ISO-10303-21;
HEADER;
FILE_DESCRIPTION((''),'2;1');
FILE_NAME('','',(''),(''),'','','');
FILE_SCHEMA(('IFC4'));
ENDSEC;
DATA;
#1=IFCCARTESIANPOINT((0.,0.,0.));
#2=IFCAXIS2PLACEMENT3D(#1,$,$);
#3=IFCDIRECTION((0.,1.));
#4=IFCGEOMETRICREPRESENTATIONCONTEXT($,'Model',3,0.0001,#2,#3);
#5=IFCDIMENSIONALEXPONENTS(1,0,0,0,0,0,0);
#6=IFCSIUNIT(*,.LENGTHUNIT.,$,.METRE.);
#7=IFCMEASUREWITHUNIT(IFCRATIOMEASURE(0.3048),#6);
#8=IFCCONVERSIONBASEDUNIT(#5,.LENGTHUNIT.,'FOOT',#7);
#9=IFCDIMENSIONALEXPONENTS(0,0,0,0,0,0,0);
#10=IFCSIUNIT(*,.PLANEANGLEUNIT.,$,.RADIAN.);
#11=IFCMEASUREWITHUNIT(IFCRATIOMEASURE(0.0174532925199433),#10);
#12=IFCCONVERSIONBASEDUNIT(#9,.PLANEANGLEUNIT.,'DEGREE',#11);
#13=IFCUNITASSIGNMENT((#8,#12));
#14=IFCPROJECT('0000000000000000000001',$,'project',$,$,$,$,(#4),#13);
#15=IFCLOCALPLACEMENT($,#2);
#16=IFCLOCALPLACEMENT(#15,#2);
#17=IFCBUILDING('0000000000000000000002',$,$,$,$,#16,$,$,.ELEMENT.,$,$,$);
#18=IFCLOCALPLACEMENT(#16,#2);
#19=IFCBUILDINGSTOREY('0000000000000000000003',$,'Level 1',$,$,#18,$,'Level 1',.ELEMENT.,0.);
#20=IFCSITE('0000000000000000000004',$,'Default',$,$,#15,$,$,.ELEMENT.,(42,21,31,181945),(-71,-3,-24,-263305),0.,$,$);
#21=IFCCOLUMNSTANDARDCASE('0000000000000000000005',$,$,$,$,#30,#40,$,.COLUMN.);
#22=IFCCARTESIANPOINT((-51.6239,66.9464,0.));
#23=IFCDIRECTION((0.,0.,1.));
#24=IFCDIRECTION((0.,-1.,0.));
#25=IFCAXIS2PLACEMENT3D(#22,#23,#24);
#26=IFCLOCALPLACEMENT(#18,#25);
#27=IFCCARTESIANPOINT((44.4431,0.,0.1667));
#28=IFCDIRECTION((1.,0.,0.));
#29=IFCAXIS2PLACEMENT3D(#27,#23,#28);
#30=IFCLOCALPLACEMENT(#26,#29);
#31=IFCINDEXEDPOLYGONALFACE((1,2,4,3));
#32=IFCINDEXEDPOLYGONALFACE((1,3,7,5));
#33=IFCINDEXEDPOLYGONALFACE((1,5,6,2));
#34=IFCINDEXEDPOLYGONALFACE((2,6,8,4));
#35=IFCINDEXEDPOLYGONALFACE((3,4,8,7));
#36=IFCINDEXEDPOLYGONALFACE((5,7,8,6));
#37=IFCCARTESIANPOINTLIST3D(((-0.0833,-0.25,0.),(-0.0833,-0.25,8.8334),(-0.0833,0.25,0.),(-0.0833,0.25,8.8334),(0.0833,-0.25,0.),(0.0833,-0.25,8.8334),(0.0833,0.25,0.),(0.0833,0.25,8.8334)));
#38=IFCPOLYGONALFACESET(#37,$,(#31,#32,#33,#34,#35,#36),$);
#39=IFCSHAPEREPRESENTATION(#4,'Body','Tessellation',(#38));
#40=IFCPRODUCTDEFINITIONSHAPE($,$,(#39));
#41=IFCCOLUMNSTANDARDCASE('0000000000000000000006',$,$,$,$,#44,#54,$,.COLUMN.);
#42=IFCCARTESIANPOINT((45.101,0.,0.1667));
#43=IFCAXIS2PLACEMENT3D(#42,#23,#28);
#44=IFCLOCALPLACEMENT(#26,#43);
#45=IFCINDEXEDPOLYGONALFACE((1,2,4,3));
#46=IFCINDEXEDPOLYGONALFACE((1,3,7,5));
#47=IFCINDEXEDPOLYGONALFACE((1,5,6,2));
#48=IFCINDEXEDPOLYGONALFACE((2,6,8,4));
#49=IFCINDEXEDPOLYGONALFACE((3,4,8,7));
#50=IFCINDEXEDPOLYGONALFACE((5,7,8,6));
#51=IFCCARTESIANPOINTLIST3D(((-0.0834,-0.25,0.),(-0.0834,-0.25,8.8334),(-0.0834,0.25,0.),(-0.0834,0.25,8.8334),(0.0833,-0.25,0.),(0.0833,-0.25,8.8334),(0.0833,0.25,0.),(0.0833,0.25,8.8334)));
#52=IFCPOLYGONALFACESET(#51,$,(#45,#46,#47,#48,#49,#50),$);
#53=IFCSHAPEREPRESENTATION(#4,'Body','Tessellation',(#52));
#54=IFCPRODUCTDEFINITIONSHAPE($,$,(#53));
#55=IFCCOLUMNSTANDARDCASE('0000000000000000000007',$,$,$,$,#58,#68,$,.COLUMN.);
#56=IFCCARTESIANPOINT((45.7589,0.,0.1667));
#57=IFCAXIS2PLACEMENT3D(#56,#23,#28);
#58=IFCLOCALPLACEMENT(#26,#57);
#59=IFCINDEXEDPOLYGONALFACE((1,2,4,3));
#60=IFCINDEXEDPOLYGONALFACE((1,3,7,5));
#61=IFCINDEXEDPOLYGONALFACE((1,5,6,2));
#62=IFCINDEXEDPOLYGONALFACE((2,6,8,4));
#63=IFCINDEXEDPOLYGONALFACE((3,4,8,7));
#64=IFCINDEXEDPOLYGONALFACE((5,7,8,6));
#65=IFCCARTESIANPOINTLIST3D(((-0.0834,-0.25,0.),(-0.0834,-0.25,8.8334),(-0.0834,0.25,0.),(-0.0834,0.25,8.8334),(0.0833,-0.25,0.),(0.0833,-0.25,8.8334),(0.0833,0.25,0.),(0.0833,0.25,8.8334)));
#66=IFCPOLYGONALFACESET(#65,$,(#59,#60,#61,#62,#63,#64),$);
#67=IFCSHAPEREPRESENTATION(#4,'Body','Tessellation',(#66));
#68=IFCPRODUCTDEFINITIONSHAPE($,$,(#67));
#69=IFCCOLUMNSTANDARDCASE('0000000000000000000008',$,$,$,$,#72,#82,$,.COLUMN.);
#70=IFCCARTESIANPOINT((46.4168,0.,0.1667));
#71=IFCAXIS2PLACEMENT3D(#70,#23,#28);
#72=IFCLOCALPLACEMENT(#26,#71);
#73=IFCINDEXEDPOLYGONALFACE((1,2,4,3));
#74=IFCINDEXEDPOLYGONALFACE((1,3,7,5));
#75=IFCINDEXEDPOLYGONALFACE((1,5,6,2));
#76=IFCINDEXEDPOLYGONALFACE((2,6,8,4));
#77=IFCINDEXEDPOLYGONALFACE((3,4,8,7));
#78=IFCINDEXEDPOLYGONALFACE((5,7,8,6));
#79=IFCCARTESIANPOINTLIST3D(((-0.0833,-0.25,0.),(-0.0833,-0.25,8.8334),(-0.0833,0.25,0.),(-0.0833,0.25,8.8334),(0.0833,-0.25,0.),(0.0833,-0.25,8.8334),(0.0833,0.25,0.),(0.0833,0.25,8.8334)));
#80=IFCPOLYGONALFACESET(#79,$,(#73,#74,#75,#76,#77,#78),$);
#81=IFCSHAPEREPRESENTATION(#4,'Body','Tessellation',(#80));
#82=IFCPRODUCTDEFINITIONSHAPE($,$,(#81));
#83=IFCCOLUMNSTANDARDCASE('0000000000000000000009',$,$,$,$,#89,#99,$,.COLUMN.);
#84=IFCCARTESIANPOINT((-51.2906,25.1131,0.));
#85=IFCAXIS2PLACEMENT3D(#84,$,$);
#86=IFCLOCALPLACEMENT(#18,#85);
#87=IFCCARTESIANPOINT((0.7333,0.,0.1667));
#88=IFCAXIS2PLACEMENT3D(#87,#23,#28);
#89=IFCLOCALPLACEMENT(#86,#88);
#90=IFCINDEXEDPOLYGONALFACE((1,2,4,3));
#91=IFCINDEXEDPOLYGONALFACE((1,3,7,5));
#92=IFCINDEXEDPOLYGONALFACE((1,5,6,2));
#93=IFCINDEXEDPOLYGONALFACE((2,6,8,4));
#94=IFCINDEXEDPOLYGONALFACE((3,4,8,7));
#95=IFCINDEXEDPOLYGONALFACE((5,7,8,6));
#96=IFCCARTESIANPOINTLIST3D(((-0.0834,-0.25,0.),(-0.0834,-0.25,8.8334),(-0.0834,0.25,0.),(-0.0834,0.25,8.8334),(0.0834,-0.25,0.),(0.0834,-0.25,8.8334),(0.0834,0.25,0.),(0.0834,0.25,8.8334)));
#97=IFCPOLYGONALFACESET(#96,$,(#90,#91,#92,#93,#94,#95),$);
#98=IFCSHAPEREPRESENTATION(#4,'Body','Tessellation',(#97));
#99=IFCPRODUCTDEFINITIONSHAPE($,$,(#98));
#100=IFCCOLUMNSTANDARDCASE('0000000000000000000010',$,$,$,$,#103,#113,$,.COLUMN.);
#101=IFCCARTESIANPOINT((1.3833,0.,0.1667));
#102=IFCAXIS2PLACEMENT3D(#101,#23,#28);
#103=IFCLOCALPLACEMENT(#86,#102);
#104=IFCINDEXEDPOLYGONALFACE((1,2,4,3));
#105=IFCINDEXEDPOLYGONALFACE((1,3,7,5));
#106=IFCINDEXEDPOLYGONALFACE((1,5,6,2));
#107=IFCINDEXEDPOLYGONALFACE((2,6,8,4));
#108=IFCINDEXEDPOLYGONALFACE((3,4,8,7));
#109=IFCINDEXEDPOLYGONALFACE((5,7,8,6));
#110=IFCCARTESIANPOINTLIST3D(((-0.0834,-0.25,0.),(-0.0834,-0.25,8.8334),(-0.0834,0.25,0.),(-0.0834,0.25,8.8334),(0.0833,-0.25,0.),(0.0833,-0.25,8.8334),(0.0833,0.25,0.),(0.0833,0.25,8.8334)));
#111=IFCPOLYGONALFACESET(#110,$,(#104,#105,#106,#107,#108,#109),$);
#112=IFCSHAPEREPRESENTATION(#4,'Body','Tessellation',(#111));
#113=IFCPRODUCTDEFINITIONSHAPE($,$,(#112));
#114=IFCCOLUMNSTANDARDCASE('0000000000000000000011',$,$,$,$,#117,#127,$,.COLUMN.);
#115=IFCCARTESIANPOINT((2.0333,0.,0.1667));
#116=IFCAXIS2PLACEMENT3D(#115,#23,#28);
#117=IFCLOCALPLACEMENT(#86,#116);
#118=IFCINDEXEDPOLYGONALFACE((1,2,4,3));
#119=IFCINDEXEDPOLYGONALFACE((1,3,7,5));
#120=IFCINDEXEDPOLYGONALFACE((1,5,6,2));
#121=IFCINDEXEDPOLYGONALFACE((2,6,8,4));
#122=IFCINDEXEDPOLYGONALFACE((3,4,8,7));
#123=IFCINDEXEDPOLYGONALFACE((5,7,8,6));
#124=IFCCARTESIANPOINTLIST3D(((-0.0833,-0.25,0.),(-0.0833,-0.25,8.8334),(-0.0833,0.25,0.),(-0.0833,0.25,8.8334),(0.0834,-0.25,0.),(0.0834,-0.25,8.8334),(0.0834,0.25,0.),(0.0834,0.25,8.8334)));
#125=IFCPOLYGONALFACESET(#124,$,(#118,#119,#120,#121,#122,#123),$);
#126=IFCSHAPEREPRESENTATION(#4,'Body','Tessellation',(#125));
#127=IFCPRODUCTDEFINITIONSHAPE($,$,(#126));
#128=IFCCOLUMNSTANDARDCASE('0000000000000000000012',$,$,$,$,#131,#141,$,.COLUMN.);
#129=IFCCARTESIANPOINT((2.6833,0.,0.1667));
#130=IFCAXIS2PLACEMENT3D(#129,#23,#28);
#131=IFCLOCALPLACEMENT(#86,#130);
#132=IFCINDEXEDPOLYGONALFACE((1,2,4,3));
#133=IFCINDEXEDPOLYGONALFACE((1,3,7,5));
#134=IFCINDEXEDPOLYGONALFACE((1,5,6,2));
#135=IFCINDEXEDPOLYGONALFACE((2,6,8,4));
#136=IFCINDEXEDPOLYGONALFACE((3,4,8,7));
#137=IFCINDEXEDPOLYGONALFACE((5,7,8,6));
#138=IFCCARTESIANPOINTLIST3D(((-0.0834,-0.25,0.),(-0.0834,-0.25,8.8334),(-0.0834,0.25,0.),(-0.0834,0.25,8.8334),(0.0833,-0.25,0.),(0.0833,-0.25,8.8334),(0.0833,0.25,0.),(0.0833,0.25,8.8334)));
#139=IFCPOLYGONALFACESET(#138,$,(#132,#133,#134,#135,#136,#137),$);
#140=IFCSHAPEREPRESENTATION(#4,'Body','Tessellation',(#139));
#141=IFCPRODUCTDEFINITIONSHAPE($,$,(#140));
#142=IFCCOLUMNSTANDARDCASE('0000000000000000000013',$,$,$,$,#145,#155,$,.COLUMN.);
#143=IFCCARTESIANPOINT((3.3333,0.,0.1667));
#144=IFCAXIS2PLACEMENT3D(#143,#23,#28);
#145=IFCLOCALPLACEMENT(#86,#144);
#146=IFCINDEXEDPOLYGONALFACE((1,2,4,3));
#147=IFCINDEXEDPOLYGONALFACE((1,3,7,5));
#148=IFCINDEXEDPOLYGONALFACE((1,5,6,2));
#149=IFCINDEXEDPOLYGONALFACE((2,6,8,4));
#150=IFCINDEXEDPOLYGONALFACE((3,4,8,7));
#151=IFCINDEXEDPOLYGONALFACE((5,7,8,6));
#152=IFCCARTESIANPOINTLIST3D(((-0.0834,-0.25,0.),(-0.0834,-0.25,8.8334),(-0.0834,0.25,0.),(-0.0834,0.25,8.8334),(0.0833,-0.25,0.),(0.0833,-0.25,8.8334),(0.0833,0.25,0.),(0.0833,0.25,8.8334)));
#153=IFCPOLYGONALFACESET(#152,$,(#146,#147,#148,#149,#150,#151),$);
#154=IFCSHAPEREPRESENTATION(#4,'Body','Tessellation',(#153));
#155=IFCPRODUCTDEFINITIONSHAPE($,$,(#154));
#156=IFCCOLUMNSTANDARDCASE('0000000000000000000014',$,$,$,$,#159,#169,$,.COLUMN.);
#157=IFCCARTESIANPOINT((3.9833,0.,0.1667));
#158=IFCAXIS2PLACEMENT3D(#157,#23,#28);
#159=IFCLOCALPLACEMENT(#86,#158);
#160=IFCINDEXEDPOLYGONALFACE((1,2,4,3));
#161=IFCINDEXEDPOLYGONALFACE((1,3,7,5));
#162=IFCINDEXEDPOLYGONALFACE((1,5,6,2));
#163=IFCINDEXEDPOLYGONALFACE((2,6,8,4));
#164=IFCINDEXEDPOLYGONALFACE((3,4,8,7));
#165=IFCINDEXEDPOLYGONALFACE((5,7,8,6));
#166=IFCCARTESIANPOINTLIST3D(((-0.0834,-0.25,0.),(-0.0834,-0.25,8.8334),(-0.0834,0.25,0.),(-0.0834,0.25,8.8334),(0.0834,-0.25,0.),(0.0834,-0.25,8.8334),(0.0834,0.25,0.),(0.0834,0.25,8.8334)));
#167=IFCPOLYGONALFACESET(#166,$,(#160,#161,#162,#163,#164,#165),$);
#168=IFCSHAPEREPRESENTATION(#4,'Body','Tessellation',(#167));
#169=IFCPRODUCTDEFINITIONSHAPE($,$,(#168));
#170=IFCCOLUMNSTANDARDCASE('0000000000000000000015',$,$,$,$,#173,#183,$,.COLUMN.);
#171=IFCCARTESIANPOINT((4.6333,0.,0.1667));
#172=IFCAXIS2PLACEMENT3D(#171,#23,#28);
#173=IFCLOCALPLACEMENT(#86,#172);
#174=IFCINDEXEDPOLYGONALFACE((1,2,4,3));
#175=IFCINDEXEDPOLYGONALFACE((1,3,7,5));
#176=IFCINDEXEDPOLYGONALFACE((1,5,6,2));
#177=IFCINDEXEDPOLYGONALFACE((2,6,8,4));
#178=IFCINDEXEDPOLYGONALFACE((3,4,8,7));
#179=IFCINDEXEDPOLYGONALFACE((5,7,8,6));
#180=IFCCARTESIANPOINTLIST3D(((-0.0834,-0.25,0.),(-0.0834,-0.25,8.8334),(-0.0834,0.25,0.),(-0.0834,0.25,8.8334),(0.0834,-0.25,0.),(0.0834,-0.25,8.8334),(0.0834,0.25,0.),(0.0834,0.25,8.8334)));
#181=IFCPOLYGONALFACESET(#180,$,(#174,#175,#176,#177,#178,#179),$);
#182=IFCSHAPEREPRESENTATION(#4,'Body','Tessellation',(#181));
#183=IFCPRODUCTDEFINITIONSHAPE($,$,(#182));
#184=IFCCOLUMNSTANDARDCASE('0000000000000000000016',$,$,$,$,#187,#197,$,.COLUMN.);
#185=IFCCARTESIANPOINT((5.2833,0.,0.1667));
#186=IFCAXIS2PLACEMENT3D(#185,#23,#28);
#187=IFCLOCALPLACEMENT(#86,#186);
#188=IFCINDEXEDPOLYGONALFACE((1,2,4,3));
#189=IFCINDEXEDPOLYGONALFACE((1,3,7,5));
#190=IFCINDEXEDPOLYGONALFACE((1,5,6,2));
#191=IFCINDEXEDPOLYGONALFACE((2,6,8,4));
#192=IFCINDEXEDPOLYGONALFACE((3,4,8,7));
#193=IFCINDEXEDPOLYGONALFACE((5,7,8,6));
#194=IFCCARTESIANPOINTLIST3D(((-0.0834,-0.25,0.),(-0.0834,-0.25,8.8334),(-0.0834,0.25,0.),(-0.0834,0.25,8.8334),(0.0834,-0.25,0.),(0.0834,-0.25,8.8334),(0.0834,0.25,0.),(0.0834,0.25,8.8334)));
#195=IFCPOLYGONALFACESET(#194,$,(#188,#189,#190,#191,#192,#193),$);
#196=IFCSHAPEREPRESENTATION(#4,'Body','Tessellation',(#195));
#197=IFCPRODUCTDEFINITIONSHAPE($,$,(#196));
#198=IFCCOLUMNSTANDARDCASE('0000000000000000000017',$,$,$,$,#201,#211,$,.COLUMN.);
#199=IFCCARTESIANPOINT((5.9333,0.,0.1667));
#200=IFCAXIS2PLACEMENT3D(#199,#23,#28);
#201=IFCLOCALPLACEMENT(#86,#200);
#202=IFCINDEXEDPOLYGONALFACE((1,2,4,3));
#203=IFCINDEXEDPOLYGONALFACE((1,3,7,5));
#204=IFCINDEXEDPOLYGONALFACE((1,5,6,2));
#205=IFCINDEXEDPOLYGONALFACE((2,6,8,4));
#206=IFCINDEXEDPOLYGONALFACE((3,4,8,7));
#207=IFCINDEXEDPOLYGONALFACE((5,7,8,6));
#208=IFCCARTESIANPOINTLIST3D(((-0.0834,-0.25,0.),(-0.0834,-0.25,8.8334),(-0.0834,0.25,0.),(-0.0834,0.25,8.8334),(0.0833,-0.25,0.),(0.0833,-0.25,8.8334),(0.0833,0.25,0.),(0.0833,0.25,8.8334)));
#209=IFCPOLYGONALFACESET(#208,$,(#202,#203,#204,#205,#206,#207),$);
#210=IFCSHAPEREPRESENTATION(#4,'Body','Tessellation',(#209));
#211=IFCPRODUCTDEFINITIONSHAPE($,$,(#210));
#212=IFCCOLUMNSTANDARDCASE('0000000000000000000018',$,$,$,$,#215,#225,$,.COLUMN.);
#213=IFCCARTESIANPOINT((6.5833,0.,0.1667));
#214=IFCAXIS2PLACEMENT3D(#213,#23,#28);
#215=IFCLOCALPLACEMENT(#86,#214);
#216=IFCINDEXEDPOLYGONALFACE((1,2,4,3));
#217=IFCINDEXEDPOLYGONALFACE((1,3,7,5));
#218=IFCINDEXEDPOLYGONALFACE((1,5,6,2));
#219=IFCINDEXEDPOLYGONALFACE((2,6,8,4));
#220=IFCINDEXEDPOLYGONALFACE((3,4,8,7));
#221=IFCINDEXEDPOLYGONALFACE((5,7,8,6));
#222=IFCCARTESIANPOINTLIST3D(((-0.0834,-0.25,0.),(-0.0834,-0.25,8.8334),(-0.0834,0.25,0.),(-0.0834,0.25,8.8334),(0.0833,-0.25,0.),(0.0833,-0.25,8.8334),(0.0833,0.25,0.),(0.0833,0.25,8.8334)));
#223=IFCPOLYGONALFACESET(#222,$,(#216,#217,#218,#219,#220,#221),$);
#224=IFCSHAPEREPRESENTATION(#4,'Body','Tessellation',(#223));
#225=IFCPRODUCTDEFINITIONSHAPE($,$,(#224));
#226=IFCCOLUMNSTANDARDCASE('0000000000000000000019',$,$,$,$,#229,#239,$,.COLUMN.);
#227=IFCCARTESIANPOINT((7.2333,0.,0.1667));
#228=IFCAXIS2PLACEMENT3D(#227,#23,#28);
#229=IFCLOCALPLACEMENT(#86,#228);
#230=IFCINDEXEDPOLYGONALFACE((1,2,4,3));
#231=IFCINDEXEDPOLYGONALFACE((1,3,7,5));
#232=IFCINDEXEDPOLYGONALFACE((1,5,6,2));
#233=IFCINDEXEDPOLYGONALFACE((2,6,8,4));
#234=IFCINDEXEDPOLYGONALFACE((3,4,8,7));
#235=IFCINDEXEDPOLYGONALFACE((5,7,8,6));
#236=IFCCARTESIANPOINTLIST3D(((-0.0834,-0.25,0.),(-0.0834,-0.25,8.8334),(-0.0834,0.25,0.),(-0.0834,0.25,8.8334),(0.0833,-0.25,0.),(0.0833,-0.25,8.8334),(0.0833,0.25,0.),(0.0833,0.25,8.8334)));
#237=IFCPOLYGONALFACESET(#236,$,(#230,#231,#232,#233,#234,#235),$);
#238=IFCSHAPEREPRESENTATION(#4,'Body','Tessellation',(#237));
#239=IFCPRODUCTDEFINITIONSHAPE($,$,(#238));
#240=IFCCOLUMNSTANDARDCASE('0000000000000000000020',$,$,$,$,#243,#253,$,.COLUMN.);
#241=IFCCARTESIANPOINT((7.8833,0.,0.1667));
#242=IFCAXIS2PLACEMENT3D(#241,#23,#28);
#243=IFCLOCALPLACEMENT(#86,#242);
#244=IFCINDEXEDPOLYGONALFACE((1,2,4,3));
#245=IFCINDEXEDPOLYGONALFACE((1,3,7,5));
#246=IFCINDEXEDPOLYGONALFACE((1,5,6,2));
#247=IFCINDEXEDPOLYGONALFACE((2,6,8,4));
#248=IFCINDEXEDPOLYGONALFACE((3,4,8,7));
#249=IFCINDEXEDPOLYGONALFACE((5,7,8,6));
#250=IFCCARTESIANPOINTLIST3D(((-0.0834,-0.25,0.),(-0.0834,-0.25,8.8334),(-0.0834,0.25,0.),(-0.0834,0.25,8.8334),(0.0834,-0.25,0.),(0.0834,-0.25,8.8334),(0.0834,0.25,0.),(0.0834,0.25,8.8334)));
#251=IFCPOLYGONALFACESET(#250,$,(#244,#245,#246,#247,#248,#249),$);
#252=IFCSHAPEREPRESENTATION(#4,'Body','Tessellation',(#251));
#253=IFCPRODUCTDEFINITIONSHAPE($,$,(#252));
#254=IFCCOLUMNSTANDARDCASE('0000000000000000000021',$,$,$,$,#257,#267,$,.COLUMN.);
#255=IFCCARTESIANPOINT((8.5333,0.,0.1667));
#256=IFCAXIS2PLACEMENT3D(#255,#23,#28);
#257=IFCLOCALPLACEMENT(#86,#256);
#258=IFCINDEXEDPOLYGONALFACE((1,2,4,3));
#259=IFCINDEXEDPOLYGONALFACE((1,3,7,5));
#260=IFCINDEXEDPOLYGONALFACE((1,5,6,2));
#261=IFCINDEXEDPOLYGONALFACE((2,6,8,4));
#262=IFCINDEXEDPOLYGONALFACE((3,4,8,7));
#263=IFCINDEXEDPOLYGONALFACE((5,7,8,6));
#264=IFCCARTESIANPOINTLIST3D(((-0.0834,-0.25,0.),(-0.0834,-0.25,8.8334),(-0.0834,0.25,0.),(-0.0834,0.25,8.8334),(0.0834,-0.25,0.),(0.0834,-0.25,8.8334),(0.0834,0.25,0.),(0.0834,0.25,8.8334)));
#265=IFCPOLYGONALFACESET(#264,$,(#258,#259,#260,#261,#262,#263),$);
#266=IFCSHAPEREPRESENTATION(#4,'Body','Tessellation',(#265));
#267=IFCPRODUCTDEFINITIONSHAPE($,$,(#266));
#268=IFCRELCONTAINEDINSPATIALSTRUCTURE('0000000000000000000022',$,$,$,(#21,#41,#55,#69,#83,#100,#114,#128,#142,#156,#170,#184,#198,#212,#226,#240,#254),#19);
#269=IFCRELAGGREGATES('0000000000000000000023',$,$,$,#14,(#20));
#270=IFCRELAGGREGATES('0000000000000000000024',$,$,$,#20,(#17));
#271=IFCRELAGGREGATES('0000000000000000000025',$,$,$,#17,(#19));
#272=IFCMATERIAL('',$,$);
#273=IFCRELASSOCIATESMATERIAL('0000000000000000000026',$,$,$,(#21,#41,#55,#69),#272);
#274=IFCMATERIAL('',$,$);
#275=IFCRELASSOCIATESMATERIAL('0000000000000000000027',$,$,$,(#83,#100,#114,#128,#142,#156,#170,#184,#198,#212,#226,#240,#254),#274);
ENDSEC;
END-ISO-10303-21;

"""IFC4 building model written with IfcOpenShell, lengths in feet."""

from ifc_helpers import new_model, entity, si_unit, converted_unit, direction, frame, origin, place, context, project, spatial, rectangle, extrude, material, element, save


model = new_model("IFC4")

# Units and contexts
model_context = context("Model", 3, precision=0.0001, world=origin(), true_north=direction((0.0, 1.0)))
ifc_project = project(units=[converted_unit("LENGTHUNIT", "FOOT", entity("IfcRatioMeasure", 0.3048), si_unit("LENGTHUNIT", "METRE"), dimensions=[1, 0, 0, 0, 0, 0, 0]), converted_unit("PLANEANGLEUNIT", "DEGREE", entity("IfcRatioMeasure", 0.0174532925199433), si_unit("PLANEANGLEUNIT", "RADIAN"), dimensions=[0, 0, 0, 0, 0, 0, 0])], contexts=[model_context])

# Site, building, storey
site_placement = place(None, origin())
site = spatial("IfcSite", under=ifc_project, at=site_placement, Name="Default", CompositionType="ELEMENT", RefLatitude=(42, 21, 31, 181945), RefLongitude=(-71, -3, -24, -263305), RefElevation=0.0)
building_placement = place(site_placement, origin())
building = spatial("IfcBuilding", under=site, at=building_placement, CompositionType="ELEMENT")
storey_placement = place(building_placement, origin())
storey = spatial("IfcBuildingStorey", under=building, at=storey_placement, Name="Level 1", LongName="Level 1", CompositionType="ELEMENT", Elevation=0.0)

# Columns
ifc_material_1 = material(Name="")
placement_1 = place(storey_placement, frame((-51.6239, 66.9464, 0.0), z_axis=(0.0, 0.0, 1.0), x_axis=(0.0, -1.0, 0.0)))
for number, where, z_axis, x_axis in (
    (1, (44.4431, 0.0, 0.1667), (0.0, 0.0, 1.0), (1.0, 0.0, 0.0)),
    (2, (45.101, 0.0, 0.1667), (0.0, 0.0, 1.0), (1.0, 0.0, 0.0)),
    (3, (45.7589, 0.0, 0.1667), (0.0, 0.0, 1.0), (1.0, 0.0, 0.0)),
    (4, (46.4168, 0.0, 0.1667), (0.0, 0.0, 1.0), (1.0, 0.0, 0.0)),
):
    element("IfcColumnStandardCase", number, at=place(placement_1, frame(where, z_axis=z_axis, x_axis=x_axis)), inside=storey, material=ifc_material_1, PredefinedType="COLUMN", context=model_context, shape_type="SweptSolid", body=[
        extrude(rectangle(XDim=0.1667, YDim=0.5), origin(), (0.0, 0.0, 1.0), 8.8334),
    ])
ifc_material_2 = material(Name="")
placement_2 = place(storey_placement, frame((-51.2906, 25.1131, 0.0)))
for number, where, z_axis, x_axis in (
    (5, (0.7333, 0.0, 0.1667), (0.0, 0.0, 1.0), (1.0, 0.0, 0.0)),
    (6, (1.3833, 0.0, 0.1667), (0.0, 0.0, 1.0), (1.0, 0.0, 0.0)),
    (7, (2.0333, 0.0, 0.1667), (0.0, 0.0, 1.0), (1.0, 0.0, 0.0)),
    (8, (2.6833, 0.0, 0.1667), (0.0, 0.0, 1.0), (1.0, 0.0, 0.0)),
    (9, (3.3333, 0.0, 0.1667), (0.0, 0.0, 1.0), (1.0, 0.0, 0.0)),
    (10, (3.9833, 0.0, 0.1667), (0.0, 0.0, 1.0), (1.0, 0.0, 0.0)),
    (11, (4.6333, 0.0, 0.1667), (0.0, 0.0, 1.0), (1.0, 0.0, 0.0)),
    (12, (5.2833, 0.0, 0.1667), (0.0, 0.0, 1.0), (1.0, 0.0, 0.0)),
    (13, (5.9333, 0.0, 0.1667), (0.0, 0.0, 1.0), (1.0, 0.0, 0.0)),
    (14, (6.5833, 0.0, 0.1667), (0.0, 0.0, 1.0), (1.0, 0.0, 0.0)),
    (15, (7.2333, 0.0, 0.1667), (0.0, 0.0, 1.0), (1.0, 0.0, 0.0)),
    (16, (7.8833, 0.0, 0.1667), (0.0, 0.0, 1.0), (1.0, 0.0, 0.0)),
    (17, (8.5333, 0.0, 0.1667), (0.0, 0.0, 1.0), (1.0, 0.0, 0.0)),
):
    element("IfcColumnStandardCase", number, at=place(placement_2, frame(where, z_axis=z_axis, x_axis=x_axis)), inside=storey, material=ifc_material_2, PredefinedType="COLUMN", context=model_context, shape_type="SweptSolid", body=[
        extrude(rectangle(XDim=0.1667, YDim=0.5), origin(), (0.0, 0.0, 1.0), 8.8334),
    ])

save(model, "model.ifc")
